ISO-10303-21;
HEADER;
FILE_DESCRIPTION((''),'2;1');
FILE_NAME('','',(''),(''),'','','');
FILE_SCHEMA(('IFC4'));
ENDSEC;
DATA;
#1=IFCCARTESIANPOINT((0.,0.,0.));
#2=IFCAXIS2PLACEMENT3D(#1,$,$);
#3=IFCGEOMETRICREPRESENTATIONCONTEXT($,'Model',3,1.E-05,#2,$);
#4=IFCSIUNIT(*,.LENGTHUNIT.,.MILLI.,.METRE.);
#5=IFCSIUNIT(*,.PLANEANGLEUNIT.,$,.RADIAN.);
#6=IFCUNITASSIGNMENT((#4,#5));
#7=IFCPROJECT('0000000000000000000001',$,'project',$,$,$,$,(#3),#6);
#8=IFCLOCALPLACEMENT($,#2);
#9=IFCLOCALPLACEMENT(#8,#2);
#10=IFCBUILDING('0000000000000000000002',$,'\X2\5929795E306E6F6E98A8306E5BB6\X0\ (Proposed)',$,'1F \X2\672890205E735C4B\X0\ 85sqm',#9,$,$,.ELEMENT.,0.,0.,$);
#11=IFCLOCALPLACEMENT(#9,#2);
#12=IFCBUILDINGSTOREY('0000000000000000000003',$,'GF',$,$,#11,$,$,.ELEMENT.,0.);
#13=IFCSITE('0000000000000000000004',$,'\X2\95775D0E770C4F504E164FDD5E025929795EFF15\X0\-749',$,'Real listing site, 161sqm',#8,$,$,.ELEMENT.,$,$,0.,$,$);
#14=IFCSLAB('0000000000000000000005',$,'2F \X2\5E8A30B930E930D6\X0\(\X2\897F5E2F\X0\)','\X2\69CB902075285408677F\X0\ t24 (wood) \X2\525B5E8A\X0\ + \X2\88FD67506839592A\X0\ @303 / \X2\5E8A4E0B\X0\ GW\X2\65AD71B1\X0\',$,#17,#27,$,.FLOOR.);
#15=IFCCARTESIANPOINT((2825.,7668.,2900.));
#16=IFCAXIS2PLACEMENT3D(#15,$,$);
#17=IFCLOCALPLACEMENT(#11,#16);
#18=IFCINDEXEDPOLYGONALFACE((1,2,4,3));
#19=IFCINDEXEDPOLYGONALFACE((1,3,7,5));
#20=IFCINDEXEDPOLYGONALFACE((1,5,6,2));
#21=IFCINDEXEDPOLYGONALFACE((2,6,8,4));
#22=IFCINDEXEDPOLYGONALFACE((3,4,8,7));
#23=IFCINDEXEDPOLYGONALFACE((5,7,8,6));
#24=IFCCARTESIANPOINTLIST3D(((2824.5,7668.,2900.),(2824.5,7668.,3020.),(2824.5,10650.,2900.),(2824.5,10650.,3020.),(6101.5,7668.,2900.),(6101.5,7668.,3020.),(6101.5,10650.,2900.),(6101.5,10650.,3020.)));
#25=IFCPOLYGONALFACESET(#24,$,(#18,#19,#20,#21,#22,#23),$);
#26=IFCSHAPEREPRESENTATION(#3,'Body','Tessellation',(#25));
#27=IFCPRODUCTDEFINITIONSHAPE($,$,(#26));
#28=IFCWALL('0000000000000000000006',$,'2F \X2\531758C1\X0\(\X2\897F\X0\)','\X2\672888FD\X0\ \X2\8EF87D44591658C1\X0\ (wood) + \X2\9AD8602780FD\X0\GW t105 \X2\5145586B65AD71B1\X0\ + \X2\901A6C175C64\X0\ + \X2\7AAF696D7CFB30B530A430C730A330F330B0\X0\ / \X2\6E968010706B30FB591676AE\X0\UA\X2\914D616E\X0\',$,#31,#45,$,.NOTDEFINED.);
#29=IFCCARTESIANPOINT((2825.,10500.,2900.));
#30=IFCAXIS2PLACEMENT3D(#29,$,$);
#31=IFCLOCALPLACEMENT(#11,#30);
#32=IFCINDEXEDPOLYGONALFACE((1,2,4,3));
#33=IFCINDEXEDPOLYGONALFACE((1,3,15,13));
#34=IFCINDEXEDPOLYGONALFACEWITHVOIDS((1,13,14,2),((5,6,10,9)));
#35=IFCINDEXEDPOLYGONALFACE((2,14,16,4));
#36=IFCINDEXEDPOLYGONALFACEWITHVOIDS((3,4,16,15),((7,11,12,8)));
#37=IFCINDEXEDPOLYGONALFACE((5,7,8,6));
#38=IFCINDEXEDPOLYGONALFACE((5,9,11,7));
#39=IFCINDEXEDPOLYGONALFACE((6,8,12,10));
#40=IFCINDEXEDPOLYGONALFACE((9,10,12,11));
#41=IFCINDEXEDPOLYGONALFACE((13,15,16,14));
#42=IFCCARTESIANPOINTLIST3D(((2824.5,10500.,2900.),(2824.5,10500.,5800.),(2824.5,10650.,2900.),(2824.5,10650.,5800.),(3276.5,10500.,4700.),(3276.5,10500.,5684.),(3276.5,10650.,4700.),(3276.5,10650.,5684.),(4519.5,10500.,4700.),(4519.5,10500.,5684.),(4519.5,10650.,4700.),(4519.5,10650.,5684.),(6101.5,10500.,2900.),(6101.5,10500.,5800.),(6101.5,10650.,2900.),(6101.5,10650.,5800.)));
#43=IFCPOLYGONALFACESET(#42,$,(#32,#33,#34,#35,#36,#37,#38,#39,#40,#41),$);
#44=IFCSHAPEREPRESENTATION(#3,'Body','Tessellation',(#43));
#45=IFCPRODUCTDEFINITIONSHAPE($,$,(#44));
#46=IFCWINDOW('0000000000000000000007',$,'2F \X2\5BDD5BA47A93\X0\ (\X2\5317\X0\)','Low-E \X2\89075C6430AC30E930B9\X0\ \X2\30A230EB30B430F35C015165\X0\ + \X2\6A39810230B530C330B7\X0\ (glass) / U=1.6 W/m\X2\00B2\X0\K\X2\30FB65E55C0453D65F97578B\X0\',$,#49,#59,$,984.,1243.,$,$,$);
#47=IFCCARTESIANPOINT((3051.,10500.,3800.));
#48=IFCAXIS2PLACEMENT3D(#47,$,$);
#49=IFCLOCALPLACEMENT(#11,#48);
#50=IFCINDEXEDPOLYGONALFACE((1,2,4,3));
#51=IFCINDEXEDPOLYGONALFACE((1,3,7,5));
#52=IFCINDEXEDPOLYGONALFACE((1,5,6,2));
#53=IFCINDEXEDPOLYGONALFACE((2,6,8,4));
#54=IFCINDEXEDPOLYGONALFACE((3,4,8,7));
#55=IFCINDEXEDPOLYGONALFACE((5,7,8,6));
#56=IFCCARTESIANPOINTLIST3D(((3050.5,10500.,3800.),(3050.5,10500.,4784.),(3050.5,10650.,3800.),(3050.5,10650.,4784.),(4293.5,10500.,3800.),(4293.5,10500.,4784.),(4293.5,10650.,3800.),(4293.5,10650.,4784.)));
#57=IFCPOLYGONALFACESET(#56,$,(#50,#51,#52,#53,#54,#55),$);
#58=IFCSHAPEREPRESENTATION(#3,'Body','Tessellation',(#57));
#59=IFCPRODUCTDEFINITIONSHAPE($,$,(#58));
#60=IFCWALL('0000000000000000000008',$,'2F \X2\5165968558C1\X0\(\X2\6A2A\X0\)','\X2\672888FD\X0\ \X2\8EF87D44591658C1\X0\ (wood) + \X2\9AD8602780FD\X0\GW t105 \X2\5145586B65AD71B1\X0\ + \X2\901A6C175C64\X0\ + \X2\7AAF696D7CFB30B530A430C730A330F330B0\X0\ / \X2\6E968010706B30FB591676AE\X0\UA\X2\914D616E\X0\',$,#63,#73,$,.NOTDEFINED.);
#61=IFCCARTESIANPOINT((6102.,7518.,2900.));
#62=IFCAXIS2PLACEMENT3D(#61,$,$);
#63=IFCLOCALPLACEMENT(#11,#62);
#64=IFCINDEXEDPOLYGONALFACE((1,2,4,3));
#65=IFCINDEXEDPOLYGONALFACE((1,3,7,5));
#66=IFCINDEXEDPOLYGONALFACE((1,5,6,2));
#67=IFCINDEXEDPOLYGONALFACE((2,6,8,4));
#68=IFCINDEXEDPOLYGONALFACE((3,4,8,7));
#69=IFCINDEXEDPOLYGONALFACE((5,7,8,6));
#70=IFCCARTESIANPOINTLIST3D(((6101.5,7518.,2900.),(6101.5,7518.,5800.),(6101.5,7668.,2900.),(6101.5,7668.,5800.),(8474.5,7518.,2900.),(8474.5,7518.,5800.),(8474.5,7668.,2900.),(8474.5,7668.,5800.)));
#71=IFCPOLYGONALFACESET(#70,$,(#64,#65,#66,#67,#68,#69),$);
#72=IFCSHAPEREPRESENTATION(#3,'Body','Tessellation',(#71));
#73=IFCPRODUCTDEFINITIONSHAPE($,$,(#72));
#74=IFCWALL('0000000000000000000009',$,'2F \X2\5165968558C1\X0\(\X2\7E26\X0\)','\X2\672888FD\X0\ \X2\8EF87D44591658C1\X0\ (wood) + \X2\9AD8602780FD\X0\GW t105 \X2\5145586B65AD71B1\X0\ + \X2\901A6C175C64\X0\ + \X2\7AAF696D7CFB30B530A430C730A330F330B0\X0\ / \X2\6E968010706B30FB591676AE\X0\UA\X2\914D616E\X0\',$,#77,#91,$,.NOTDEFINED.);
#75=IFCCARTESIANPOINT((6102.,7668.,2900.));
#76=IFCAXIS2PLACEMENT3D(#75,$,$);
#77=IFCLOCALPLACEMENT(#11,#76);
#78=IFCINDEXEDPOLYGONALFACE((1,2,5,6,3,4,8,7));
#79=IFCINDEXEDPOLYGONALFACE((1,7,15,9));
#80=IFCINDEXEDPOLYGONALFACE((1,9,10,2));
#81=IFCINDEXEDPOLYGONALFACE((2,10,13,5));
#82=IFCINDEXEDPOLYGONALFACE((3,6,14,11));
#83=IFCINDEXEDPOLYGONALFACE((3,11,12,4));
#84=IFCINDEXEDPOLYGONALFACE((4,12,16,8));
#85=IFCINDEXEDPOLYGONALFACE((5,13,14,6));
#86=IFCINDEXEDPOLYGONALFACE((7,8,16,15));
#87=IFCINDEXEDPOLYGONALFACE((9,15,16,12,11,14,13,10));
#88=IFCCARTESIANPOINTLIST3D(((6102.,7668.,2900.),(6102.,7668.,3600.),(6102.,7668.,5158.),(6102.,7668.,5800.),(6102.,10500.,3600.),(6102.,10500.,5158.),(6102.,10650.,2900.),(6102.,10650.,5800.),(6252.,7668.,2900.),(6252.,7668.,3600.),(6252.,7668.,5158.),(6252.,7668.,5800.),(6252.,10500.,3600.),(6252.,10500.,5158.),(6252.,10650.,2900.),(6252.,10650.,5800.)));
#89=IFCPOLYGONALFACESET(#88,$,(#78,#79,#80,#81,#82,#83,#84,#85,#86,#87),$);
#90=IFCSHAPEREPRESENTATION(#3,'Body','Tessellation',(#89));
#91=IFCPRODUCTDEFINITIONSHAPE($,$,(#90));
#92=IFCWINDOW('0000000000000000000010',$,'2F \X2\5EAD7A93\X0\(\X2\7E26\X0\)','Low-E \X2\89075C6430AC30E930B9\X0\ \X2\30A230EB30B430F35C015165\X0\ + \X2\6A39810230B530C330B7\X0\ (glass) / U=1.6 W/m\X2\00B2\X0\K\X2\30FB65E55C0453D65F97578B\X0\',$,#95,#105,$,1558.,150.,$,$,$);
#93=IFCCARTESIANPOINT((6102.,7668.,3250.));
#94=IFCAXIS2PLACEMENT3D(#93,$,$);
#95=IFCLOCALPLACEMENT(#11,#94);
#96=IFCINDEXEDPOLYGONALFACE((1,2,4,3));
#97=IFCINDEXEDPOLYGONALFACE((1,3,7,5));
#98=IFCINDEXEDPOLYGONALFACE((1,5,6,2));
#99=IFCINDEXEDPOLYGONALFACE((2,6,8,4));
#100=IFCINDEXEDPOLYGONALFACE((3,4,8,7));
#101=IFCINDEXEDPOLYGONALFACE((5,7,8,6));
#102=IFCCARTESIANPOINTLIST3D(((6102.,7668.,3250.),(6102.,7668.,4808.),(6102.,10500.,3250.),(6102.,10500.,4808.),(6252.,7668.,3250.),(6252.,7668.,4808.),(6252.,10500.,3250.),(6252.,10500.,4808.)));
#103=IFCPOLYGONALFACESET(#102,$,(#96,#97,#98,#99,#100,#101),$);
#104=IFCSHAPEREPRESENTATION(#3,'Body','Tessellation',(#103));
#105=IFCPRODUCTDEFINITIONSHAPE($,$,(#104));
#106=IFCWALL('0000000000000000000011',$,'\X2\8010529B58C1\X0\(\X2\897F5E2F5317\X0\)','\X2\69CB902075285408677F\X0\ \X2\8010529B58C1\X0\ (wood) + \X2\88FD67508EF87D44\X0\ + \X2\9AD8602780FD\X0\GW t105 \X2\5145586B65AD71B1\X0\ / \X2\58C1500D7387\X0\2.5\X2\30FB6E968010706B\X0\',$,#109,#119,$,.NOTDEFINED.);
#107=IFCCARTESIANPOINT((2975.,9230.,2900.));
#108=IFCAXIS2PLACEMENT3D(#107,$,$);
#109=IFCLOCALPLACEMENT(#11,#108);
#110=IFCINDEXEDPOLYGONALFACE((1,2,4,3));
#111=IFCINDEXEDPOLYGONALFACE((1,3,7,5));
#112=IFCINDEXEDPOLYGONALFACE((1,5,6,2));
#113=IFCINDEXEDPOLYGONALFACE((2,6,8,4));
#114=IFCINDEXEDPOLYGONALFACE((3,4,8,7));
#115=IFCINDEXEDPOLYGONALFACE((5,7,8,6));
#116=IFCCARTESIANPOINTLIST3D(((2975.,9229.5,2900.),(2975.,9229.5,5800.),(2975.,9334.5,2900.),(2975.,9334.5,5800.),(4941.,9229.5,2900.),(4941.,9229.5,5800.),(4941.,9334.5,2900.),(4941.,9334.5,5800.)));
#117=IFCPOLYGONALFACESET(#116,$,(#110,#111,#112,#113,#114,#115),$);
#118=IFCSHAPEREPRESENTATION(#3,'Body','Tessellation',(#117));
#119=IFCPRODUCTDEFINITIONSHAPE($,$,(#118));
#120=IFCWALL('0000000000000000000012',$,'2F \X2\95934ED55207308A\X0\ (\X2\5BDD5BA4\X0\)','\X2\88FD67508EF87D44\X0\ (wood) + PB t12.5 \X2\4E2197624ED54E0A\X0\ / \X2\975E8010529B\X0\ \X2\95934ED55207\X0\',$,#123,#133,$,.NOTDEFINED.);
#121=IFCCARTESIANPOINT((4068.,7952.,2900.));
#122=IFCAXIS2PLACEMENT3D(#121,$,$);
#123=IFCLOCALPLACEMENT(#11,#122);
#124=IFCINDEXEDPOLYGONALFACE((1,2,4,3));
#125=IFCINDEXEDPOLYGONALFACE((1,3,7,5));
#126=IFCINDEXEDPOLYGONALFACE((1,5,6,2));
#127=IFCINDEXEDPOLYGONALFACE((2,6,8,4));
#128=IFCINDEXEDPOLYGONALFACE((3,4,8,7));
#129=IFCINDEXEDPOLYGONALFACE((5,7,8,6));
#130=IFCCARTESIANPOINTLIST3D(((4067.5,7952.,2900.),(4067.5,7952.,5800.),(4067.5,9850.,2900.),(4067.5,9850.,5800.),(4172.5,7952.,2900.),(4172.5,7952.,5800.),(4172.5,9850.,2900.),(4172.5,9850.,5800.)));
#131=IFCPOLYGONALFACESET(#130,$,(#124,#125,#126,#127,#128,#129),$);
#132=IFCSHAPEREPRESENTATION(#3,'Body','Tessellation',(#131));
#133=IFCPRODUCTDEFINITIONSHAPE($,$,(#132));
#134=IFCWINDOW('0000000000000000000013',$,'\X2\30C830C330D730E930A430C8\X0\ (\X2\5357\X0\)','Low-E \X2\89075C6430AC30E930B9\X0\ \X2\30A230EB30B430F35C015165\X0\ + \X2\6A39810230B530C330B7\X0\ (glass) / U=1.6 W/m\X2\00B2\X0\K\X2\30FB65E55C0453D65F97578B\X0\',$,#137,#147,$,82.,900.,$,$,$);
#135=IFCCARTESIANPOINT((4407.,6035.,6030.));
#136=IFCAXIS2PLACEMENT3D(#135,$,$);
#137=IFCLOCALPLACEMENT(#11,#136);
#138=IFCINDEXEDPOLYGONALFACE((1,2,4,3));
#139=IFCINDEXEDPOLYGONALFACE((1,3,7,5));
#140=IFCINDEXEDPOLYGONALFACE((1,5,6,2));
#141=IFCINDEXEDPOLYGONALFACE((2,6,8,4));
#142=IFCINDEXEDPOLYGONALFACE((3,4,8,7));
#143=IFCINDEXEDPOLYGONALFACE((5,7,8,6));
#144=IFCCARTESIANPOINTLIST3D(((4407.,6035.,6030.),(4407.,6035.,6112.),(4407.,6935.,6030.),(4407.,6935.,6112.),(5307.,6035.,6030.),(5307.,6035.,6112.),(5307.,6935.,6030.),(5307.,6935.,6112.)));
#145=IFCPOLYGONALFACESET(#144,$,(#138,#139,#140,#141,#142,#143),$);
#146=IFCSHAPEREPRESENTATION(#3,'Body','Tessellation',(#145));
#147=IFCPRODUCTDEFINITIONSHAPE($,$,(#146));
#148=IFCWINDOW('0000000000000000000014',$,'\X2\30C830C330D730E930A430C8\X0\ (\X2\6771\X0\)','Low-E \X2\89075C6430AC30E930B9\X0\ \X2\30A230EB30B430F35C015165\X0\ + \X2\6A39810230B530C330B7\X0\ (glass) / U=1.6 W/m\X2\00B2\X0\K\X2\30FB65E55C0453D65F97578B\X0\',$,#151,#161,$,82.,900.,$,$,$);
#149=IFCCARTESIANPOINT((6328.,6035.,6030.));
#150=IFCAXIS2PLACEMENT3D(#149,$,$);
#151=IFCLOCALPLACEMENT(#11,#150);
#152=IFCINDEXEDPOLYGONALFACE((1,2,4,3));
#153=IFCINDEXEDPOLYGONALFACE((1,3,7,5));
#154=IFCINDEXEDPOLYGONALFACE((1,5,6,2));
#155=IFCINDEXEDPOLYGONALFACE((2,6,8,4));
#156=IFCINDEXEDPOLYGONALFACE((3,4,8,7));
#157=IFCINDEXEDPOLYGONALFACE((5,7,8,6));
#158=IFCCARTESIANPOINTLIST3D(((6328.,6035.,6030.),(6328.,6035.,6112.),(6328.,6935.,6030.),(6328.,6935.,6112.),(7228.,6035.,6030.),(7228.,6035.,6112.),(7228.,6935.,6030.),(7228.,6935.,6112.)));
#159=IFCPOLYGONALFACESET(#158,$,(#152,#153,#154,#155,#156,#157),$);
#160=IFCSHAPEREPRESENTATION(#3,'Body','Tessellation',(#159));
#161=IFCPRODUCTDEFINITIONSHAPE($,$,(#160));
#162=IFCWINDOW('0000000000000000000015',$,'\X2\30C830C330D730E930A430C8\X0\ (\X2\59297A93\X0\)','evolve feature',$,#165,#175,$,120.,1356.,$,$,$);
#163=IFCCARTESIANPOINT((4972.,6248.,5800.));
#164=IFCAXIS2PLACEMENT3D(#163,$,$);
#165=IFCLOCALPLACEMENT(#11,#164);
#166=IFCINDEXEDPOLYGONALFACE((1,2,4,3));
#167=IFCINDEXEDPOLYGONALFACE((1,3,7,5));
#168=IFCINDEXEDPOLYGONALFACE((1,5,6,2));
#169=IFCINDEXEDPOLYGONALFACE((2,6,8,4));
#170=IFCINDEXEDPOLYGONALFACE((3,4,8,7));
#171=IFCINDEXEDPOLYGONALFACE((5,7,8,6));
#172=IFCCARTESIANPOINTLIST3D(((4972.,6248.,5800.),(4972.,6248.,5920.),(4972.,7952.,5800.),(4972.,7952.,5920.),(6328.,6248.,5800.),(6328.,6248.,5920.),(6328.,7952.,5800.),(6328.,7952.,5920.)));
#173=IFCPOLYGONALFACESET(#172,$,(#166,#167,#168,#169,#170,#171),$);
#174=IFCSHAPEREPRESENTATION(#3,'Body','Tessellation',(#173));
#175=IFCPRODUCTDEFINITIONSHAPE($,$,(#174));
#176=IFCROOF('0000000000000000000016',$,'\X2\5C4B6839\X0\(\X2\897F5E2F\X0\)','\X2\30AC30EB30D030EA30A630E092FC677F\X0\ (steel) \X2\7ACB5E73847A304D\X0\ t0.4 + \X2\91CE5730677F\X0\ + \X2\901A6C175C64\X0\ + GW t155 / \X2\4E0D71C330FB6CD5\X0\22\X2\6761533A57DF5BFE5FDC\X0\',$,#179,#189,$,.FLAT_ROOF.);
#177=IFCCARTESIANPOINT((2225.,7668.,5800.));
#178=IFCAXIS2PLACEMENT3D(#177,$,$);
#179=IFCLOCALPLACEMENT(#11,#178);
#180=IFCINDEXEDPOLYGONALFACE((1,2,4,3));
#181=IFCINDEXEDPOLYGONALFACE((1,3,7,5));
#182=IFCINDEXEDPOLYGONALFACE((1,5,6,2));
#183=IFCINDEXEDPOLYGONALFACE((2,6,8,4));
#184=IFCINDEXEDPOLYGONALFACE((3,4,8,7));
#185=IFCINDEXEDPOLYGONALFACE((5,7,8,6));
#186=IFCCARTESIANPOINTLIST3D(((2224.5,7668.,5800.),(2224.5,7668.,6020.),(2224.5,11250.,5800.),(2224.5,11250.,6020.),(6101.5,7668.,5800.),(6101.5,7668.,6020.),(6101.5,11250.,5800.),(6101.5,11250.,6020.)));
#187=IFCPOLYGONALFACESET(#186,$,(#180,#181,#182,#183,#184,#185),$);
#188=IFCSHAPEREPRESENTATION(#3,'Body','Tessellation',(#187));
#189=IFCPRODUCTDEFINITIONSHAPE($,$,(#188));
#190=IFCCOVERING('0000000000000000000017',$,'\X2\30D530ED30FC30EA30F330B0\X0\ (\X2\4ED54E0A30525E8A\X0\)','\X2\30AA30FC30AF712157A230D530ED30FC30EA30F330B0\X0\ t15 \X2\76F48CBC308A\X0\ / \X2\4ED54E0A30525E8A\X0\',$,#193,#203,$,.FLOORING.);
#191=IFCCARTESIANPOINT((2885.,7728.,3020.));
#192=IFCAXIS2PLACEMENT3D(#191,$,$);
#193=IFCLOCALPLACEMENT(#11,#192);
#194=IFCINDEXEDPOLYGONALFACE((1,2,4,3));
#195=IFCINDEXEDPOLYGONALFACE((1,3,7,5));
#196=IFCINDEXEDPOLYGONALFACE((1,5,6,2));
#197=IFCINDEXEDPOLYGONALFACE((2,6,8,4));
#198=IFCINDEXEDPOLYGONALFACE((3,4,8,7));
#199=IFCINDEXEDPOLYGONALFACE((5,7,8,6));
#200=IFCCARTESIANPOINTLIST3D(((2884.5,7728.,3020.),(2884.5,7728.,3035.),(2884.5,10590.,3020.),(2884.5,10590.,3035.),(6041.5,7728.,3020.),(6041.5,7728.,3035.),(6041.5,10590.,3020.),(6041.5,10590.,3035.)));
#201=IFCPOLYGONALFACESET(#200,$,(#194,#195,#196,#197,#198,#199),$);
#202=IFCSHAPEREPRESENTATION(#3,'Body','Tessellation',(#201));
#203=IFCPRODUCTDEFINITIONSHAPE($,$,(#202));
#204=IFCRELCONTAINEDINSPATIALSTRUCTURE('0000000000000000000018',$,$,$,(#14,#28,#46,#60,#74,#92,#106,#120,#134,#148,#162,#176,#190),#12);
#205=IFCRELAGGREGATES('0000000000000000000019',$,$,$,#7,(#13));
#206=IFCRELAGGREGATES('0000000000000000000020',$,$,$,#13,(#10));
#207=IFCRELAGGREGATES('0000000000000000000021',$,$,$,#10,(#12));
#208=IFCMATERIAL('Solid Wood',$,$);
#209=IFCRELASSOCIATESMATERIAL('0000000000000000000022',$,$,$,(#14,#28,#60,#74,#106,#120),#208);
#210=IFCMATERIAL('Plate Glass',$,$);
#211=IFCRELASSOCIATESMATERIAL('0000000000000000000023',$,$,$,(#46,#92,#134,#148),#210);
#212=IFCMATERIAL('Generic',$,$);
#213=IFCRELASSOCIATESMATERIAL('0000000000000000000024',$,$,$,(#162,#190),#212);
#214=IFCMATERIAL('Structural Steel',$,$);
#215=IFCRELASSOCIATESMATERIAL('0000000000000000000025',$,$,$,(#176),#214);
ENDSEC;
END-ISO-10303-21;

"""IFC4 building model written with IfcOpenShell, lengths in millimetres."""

from ifc_helpers import new_model, si_unit, frame, frame_2d, origin, place, context, project, spatial, rectangle, extrude, material, element, fill, save


model = new_model("IFC4")

# Units and contexts
model_context = context("Model", 3, precision=1e-05, world=origin())
ifc_project = project(units=[si_unit("LENGTHUNIT", "METRE", prefix="MILLI"), si_unit("PLANEANGLEUNIT", "RADIAN")], contexts=[model_context])

# Site, building, storey
site_placement = place(None, origin())
site = spatial("IfcSite", under=ifc_project, at=site_placement, Name="長崎県佐世保市天神５-749", ObjectType="Real listing site, 161sqm", CompositionType="ELEMENT", RefElevation=0.0)
building_placement = place(site_placement, origin())
building = spatial("IfcBuilding", under=site, at=building_placement, Name="天神の潮風の家 (Proposed)", ObjectType="1F 木造平屋 85sqm", CompositionType="ELEMENT", ElevationOfRefHeight=0.0, ElevationOfTerrain=0.0)
storey_placement = place(building_placement, origin())
storey = spatial("IfcBuildingStorey", under=building, at=storey_placement, Name="GF", CompositionType="ELEMENT", Elevation=0.0)

# Slab
ifc_material_1 = material(Name="Solid Wood")
slab_placement = place(storey_placement, frame((2825.0, 7668.0, 2900.0)))
element("IfcSlab", 1, at=slab_placement, inside=storey, material=ifc_material_1, Name="2F 床スラブ(西帯)", Description="構造用合板 t24 (wood) 剛床 + 製材根太 @303 / 床下 GW断熱", PredefinedType="FLOOR", context=model_context, shape_type="SweptSolid", body=[
    extrude(rectangle(XDim=3277.0, YDim=2982.0, at=frame_2d((1638.0, 1491.0))), frame((2825.0, 7668.0, 2900.0)), (0.0, 0.0, 1.0), 120.0),
])

# Wall, opening, window
wall_1_placement = place(storey_placement, frame((2825.0, 10500.0, 2900.0)))
wall_1 = element("IfcWall", 2, at=wall_1_placement, inside=storey, material=ifc_material_1, Name="2F 北壁(西)", Description="木製 軸組外壁 (wood) + 高性能GW t105 充填断熱 + 通気層 + 窯業系サイディング / 準耐火・外皮UA配慮", PredefinedType="NOTDEFINED", context=model_context, shape_type="SweptSolid", body=[
    extrude(rectangle(XDim=3277.0, YDim=150.0, at=frame_2d((1638.0, 75.0))), frame((2825.0, 10500.0, 2900.0)), (0.0, 0.0, 1.0), 2900.0),
])
opening_1_placement = place(storey_placement, frame((3051.0, 10500.0, 3800.0)))
opening_1 = element("IfcOpeningElement", 3, at=opening_1_placement, cuts=wall_1, PredefinedType="NOTDEFINED", context=model_context, shape_type="SweptSolid", body=[
    extrude(rectangle(XDim=1243.0, YDim=150.0, at=frame_2d((621.0, 75.0))), frame((3051.0, 10500.0, 3800.0)), (0.0, 0.0, 1.0), 984.0),
])
ifc_material_2 = material(Name="Plate Glass")
window_1_placement = place(storey_placement, frame((3051.0, 10500.0, 3800.0)))
window_1 = element("IfcWindow", 4, at=window_1_placement, inside=storey, material=ifc_material_2, Name="2F 寝室窓 (北)", Description="Low-E 複層ガラス アルゴン封入 + 樹脂サッシ (glass) / U=1.6 W/m²K・日射取得型", OverallHeight=984.0, OverallWidth=1243.0, context=model_context, shape_type="SweptSolid", body=[
    extrude(rectangle(XDim=1243.0, YDim=150.0, at=frame_2d((621.0, 75.0))), frame((3051.0, 10500.0, 3800.0)), (0.0, 0.0, 1.0), 984.0),
])
fill(opening_1, window_1)

# Wall
wall_2_placement = place(storey_placement, frame((6102.0, 7518.0, 2900.0)))
element("IfcWall", 5, at=wall_2_placement, inside=storey, material=ifc_material_1, Name="2F 入隅壁(横)", Description="木製 軸組外壁 (wood) + 高性能GW t105 充填断熱 + 通気層 + 窯業系サイディング / 準耐火・外皮UA配慮", PredefinedType="NOTDEFINED", context=model_context, shape_type="SweptSolid", body=[
    extrude(rectangle(XDim=2373.0, YDim=150.0, at=frame_2d((1186.0, 75.0))), frame((6102.0, 7518.0, 2900.0)), (0.0, 0.0, 1.0), 2900.0),
])

# Wall, opening, window
wall_3_placement = place(storey_placement, frame((6102.0, 7668.0, 2900.0)))
wall_3 = element("IfcWall", 6, at=wall_3_placement, inside=storey, material=ifc_material_1, Name="2F 入隅壁(縦)", Description="木製 軸組外壁 (wood) + 高性能GW t105 充填断熱 + 通気層 + 窯業系サイディング / 準耐火・外皮UA配慮", PredefinedType="NOTDEFINED", context=model_context, shape_type="SweptSolid", body=[
    extrude(rectangle(XDim=150.0, YDim=2982.0, at=frame_2d((75.0, 1491.0))), frame((6102.0, 7668.0, 2900.0)), (0.0, 0.0, 1.0), 2900.0),
])
opening_2_placement = place(storey_placement, frame((6102.0, 7668.0, 3250.0)))
opening_2 = element("IfcOpeningElement", 7, at=opening_2_placement, cuts=wall_3, PredefinedType="NOTDEFINED", context=model_context, shape_type="SweptSolid", body=[
    extrude(rectangle(XDim=150.0, YDim=2832.0, at=frame_2d((75.0, 1416.0))), frame((6102.0, 7668.0, 3250.0)), (0.0, 0.0, 1.0), 1558.0),
])
window_2_placement = place(storey_placement, frame((6102.0, 7668.0, 3250.0)))
window_2 = element("IfcWindow", 8, at=window_2_placement, inside=storey, material=ifc_material_2, Name="2F 庭窓(縦)", Description="Low-E 複層ガラス アルゴン封入 + 樹脂サッシ (glass) / U=1.6 W/m²K・日射取得型", OverallHeight=1558.0, OverallWidth=150.0, context=model_context, shape_type="SweptSolid", body=[
    extrude(rectangle(XDim=150.0, YDim=2832.0, at=frame_2d((75.0, 1416.0))), frame((6102.0, 7668.0, 3250.0)), (0.0, 0.0, 1.0), 1558.0),
])
fill(opening_2, window_2)

# Walls
wall_4_placement = place(storey_placement, frame((2975.0, 9230.0, 2900.0)))
element("IfcWall", 9, at=wall_4_placement, inside=storey, material=ifc_material_1, Name="耐力壁(西帯北)", Description="構造用合板 耐力壁 (wood) + 製材軸組 + 高性能GW t105 充填断熱 / 壁倍率2.5・準耐火", PredefinedType="NOTDEFINED", context=model_context, shape_type="SweptSolid", body=[
    extrude(rectangle(XDim=1966.0, YDim=105.0, at=frame_2d((983.0, 52.0))), frame((2975.0, 9230.0, 2900.0)), (0.0, 0.0, 1.0), 2900.0),
])
wall_5_placement = place(storey_placement, frame((4068.0, 7952.0, 2900.0)))
element("IfcWall", 10, at=wall_5_placement, inside=storey, material=ifc_material_1, Name="2F 間仕切り (寝室)", Description="製材軸組 (wood) + PB t12.5 両面仕上 / 非耐力 間仕切", PredefinedType="NOTDEFINED", context=model_context, shape_type="SweptSolid", body=[
    extrude(rectangle(XDim=105.0, YDim=1898.0, at=frame_2d((52.0, 949.0))), frame((4068.0, 7952.0, 2900.0)), (0.0, 0.0, 1.0), 2900.0),
])

# Windows
window_3_placement = place(storey_placement, frame((4407.0, 6035.0, 6030.0)))
element("IfcWindow", 11, at=window_3_placement, inside=storey, material=ifc_material_2, Name="トップライト (南)", Description="Low-E 複層ガラス アルゴン封入 + 樹脂サッシ (glass) / U=1.6 W/m²K・日射取得型", OverallHeight=82.0, OverallWidth=900.0, context=model_context, shape_type="SweptSolid", body=[
    extrude(rectangle(XDim=900.0, YDim=900.0, at=frame_2d((450.0, 450.0))), frame((4407.0, 6035.0, 6030.0)), (0.0, 0.0, 1.0), 82.0),
])
window_4_placement = place(storey_placement, frame((6328.0, 6035.0, 6030.0)))
element("IfcWindow", 12, at=window_4_placement, inside=storey, material=ifc_material_2, Name="トップライト (東)", Description="Low-E 複層ガラス アルゴン封入 + 樹脂サッシ (glass) / U=1.6 W/m²K・日射取得型", OverallHeight=82.0, OverallWidth=900.0, context=model_context, shape_type="SweptSolid", body=[
    extrude(rectangle(XDim=900.0, YDim=900.0, at=frame_2d((450.0, 450.0))), frame((6328.0, 6035.0, 6030.0)), (0.0, 0.0, 1.0), 82.0),
])
ifc_material_3 = material(Name="Generic")
window_5_placement = place(storey_placement, frame((4972.0, 6248.0, 5800.0)))
element("IfcWindow", 13, at=window_5_placement, inside=storey, material=ifc_material_3, Name="トップライト (天窓)", Description="evolve feature", OverallHeight=120.0, OverallWidth=1356.0, context=model_context, shape_type="SweptSolid", body=[
    extrude(rectangle(XDim=1356.0, YDim=1704.0, at=frame_2d((678.0, 852.0))), frame((4972.0, 6248.0, 5800.0)), (0.0, 0.0, 1.0), 120.0),
])

# Roof
ifc_material_4 = material(Name="Structural Steel")
for number, where, name in (
    (14, (2225.0, 7668.0, 5800.0), "屋根(西帯)"),
):
    element("IfcRoof", number, at=place(storey_placement, frame(where)), inside=storey, material=ifc_material_4, Name=name, Description="ガルバリウム鋼板 (steel) 立平葺き t0.4 + 野地板 + 通気層 + GW t155 / 不燃・法22条区域対応", PredefinedType="FLAT_ROOF", context=model_context, shape_type="SweptSolid", body=[
        extrude(rectangle(XDim=3877.0, YDim=3582.0, at=frame_2d((1938.0, 1791.0))), frame((2225.0, 7668.0, 5800.0)), (0.0, 0.0, 1.0), 220.0),
    ])

# Covering
covering_placement = place(storey_placement, frame((2885.0, 7728.0, 3020.0)))
element("IfcCovering", 15, at=covering_placement, inside=storey, material=ifc_material_3, Name="フローリング (仕上げ床)", Description="オーク無垢フローリング t15 直貼り / 仕上げ床", PredefinedType="FLOORING", context=model_context, shape_type="SweptSolid", body=[
    extrude(rectangle(XDim=3157.0, YDim=2862.0, at=frame_2d((1578.0, 1431.0))), frame((2885.0, 7728.0, 3020.0)), (0.0, 0.0, 1.0), 15.0),
])

save(model, "model.ifc")
